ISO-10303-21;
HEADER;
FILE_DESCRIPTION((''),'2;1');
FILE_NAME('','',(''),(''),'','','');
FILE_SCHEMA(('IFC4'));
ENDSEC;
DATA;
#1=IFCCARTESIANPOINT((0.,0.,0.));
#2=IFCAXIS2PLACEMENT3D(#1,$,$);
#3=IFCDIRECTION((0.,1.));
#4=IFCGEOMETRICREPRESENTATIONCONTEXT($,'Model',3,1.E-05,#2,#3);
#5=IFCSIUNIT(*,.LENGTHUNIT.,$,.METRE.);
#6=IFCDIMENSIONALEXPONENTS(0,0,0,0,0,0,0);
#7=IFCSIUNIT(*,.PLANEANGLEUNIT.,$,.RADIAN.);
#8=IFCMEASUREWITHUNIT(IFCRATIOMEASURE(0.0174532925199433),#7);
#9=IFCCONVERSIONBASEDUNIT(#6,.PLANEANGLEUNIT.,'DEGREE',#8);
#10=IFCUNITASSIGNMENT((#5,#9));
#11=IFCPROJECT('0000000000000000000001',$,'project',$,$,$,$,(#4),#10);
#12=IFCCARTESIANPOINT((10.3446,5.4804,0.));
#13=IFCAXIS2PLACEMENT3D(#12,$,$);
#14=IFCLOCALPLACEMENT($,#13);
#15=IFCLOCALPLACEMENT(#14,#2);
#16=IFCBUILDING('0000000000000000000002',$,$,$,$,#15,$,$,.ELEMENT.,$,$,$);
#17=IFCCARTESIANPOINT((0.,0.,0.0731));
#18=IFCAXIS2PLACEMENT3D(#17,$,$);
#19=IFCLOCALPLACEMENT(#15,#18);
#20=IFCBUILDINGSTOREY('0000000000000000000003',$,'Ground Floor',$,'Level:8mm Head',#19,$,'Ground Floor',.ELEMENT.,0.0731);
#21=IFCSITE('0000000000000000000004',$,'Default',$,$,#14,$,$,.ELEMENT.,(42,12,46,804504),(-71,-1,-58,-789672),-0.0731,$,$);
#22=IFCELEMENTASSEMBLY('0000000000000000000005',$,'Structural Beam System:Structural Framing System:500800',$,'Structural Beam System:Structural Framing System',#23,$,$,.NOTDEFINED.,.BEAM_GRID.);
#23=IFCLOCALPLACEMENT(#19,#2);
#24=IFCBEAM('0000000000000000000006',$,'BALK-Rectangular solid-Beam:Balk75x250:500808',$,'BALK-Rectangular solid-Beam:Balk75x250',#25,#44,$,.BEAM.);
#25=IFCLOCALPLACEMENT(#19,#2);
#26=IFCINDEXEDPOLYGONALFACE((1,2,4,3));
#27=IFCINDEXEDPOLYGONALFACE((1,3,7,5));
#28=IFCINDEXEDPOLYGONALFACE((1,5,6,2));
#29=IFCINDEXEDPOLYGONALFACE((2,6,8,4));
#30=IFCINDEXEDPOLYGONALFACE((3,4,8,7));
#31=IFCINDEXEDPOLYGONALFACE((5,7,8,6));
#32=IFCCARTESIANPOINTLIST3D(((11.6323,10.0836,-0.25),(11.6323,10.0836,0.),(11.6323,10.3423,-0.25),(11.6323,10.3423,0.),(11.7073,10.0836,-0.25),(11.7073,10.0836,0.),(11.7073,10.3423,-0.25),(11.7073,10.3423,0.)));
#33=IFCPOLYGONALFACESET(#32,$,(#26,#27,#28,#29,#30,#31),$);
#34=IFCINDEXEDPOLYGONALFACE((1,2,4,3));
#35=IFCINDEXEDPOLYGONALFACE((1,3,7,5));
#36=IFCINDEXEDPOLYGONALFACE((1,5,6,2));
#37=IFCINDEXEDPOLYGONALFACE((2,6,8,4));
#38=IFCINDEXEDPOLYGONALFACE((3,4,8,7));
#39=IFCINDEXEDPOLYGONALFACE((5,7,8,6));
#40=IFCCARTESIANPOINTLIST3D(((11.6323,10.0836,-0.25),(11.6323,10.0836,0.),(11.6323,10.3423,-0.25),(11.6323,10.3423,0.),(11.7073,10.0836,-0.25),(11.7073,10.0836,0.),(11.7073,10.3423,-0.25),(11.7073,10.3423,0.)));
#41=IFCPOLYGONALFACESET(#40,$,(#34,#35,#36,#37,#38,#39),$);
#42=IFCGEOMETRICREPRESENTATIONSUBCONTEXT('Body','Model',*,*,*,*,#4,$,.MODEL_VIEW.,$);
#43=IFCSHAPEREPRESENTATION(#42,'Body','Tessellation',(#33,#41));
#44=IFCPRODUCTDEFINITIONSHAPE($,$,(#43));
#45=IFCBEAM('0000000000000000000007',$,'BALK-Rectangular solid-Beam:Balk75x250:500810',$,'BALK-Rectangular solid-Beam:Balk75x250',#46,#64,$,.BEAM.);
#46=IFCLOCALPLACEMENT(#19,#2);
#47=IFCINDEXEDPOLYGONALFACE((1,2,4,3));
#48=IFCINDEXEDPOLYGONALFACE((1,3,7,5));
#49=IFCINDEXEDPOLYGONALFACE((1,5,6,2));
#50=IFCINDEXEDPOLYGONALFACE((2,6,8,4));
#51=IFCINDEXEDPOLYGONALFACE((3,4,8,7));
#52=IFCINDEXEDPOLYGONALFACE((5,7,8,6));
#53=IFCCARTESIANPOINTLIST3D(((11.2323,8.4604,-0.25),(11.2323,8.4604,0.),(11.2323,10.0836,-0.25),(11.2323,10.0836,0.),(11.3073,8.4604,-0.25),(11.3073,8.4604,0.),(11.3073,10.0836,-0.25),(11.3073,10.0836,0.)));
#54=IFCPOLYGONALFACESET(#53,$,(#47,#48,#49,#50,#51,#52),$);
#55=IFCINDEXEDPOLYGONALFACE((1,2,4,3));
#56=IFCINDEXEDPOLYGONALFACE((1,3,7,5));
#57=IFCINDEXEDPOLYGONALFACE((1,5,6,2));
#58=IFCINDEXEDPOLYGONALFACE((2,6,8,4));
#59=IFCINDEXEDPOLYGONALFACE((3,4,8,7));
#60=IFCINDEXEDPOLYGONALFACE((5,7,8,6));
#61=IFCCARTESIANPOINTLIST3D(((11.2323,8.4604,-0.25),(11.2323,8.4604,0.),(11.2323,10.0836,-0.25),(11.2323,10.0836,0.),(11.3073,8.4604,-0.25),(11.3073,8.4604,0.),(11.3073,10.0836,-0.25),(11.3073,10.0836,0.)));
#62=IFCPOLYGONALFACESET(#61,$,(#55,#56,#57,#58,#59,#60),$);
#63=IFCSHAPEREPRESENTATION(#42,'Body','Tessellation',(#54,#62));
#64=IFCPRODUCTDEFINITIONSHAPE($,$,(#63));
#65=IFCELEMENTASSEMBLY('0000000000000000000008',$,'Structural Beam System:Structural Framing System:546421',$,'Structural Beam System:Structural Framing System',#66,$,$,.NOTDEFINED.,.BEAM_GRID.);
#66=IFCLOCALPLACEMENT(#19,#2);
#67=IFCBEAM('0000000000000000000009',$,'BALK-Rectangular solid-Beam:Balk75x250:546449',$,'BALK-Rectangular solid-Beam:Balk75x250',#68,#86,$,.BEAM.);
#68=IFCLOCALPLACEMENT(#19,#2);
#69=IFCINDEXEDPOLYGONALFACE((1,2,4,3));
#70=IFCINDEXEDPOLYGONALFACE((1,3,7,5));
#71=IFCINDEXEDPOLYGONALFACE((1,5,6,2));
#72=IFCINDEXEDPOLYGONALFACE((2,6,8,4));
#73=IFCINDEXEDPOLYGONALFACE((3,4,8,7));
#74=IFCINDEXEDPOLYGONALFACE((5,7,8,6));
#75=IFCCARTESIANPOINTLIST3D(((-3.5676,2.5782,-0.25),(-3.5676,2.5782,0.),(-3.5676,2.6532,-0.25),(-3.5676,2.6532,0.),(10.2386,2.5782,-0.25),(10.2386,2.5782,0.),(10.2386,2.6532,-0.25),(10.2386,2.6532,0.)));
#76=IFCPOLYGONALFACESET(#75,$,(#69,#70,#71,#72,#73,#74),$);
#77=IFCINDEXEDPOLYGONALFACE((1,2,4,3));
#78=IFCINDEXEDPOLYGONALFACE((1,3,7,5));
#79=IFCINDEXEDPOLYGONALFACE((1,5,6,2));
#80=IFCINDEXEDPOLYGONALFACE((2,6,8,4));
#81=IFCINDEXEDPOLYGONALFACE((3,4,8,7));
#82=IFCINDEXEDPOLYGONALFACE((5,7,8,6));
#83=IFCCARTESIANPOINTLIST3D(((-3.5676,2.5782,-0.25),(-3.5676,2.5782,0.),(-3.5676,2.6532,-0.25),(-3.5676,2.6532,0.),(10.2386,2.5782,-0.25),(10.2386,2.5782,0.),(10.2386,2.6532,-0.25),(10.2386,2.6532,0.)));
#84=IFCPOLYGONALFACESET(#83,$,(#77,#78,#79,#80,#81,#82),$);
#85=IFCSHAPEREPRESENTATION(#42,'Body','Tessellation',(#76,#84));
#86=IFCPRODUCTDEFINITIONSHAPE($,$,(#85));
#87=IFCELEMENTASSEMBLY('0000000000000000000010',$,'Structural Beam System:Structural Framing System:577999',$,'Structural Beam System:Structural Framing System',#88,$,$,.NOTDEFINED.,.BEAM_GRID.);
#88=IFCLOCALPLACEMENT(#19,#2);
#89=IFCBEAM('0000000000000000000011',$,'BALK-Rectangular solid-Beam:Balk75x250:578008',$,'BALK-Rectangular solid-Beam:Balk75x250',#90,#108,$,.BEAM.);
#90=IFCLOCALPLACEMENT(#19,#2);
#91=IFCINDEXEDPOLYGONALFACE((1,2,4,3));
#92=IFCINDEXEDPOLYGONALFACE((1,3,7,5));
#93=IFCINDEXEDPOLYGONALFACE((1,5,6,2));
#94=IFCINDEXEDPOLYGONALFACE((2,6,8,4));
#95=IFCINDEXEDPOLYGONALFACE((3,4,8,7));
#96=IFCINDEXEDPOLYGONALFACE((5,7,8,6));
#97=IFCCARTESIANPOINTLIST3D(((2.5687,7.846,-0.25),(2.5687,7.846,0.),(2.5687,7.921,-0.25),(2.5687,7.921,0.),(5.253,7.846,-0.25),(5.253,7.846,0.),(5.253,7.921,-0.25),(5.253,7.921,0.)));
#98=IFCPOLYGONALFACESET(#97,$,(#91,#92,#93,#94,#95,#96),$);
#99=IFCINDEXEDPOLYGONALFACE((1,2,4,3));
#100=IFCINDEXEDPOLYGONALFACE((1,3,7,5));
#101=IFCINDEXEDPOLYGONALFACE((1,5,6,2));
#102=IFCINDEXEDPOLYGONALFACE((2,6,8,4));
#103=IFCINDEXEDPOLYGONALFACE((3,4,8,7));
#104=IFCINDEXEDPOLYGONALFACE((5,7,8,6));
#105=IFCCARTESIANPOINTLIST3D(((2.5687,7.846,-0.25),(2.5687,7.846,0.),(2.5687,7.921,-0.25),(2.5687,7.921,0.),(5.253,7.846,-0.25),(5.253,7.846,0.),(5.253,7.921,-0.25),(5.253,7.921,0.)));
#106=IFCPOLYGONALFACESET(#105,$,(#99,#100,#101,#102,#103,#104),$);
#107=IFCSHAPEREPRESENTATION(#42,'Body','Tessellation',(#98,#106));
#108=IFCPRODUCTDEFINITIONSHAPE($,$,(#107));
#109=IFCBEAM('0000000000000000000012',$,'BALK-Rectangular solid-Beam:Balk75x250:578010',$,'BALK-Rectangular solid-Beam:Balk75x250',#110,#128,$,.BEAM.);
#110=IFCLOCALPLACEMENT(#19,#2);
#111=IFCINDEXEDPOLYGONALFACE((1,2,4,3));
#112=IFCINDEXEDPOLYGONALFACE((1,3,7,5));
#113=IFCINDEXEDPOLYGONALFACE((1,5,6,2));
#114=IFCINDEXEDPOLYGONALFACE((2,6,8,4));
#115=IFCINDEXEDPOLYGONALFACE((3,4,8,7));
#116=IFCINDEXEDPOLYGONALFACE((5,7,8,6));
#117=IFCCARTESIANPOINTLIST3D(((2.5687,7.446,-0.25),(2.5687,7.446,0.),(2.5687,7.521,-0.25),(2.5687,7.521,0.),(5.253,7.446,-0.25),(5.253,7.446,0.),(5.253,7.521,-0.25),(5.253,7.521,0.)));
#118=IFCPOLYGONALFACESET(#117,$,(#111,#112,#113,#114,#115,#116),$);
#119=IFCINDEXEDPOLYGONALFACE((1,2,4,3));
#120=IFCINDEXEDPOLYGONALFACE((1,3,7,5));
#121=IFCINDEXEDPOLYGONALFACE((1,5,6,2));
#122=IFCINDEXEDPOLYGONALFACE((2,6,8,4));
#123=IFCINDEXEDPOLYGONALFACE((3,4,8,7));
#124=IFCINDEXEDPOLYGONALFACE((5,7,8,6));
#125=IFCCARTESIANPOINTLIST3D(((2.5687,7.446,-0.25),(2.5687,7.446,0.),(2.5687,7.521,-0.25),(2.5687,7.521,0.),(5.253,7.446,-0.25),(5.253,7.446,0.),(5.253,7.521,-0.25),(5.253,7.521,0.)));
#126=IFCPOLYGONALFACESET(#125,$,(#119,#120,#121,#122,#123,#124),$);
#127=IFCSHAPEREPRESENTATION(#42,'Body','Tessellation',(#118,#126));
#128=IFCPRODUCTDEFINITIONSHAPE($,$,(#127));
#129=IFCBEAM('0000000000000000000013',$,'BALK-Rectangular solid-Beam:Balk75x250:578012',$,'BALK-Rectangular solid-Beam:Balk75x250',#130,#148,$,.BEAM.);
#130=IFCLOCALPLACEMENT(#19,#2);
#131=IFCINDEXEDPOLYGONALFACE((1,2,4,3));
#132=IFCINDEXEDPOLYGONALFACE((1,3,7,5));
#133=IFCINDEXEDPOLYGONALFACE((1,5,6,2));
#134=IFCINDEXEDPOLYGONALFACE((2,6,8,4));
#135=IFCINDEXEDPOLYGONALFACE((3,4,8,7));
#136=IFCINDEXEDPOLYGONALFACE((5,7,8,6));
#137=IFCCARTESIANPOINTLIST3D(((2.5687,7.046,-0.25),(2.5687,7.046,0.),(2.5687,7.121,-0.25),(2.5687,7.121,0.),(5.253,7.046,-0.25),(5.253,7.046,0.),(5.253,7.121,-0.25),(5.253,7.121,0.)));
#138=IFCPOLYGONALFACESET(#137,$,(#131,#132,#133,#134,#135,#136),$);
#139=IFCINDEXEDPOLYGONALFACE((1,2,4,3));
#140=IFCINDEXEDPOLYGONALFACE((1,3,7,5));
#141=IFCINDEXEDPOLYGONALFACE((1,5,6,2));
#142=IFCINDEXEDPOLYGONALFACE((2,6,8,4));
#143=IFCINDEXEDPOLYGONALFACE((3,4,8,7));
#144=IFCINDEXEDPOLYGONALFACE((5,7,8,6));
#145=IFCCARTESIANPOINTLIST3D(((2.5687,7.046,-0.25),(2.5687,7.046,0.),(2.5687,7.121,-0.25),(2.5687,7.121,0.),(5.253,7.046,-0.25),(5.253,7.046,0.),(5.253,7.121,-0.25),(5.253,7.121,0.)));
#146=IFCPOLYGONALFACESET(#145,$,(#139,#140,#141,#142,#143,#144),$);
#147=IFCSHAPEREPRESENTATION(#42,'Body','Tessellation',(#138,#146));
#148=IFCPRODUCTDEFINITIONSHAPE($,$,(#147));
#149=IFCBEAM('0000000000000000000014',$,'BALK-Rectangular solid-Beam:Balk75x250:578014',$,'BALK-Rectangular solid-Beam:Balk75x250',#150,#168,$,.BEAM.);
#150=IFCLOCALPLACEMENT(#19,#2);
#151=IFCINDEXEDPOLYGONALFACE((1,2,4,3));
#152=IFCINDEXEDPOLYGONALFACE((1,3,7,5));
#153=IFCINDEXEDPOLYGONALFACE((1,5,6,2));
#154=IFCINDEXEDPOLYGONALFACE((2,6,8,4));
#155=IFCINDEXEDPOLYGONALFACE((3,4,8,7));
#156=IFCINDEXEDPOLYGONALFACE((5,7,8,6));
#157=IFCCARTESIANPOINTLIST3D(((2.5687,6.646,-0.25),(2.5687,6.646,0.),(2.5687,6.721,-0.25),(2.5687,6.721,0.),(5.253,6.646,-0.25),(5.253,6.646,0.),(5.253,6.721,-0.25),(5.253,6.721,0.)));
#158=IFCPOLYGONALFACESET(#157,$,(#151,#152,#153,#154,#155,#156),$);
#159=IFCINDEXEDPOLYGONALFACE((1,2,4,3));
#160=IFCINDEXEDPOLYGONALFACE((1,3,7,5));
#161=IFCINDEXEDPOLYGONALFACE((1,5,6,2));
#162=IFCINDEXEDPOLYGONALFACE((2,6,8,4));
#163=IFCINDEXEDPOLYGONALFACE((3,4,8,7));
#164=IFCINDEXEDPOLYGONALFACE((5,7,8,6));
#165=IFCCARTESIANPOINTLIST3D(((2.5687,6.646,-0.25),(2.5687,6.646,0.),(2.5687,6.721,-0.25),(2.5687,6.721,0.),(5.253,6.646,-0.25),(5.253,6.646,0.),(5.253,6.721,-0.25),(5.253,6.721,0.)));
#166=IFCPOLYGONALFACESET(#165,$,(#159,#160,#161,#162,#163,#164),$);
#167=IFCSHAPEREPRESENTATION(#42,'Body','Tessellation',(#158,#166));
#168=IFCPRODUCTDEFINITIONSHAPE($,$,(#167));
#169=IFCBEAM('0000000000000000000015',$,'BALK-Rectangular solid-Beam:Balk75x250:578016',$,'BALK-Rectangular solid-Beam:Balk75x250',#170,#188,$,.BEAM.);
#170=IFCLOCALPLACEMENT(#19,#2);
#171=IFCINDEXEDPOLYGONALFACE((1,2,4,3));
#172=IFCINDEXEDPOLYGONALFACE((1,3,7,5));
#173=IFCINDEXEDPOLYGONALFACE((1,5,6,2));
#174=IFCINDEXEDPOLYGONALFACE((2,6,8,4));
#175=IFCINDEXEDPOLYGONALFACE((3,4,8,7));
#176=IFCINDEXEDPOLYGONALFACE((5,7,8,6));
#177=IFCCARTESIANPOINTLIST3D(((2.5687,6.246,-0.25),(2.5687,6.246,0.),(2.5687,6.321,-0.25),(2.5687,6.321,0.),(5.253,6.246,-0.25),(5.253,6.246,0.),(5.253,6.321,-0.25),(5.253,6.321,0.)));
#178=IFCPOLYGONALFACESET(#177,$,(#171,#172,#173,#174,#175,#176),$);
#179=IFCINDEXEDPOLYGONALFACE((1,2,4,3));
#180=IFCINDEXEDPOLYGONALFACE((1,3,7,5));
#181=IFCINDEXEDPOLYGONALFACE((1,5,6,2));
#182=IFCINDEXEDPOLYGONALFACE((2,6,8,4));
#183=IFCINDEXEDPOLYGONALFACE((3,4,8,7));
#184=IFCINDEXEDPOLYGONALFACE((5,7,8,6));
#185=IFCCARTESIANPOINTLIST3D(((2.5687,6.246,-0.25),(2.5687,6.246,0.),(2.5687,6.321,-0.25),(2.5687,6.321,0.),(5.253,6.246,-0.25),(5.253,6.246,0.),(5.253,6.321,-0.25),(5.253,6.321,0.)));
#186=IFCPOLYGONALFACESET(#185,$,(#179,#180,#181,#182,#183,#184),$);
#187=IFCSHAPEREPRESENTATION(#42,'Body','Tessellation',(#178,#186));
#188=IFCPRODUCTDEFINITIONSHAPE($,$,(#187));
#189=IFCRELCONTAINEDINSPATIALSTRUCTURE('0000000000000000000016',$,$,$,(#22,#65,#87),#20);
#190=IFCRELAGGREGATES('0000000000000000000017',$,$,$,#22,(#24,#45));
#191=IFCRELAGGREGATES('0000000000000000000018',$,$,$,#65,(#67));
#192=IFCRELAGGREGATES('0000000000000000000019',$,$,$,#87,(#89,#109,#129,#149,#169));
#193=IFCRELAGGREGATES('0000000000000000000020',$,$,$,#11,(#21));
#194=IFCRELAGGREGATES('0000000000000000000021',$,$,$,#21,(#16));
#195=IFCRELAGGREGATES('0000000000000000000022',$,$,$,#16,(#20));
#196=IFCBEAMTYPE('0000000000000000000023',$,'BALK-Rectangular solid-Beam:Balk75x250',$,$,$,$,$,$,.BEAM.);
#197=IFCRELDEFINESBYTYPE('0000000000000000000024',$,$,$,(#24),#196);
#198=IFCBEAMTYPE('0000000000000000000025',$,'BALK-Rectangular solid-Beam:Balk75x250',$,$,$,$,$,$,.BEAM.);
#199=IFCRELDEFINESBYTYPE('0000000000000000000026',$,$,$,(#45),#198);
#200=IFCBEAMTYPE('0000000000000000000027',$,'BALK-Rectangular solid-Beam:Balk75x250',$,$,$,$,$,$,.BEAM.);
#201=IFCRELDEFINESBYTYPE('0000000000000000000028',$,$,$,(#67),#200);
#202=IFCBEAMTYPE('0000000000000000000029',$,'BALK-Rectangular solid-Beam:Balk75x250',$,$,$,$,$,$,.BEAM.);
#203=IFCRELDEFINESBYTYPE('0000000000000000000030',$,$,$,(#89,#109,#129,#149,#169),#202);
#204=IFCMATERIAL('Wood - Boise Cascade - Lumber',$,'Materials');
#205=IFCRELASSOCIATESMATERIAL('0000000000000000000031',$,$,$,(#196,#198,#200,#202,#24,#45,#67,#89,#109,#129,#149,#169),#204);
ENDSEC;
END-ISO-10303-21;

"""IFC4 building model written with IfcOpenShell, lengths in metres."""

from ifc_helpers import new_model, entity, si_unit, converted_unit, direction, frame, frame_2d, origin, origin_2d_with_axis, place, context, subcontext, project, spatial, rectangle, extrude, source, transform, mapped, material, material_profile, profile_set, profile_usage, type_object, type_shapes, element, aggregate, save


model = new_model("IFC4")

# Units and contexts
model_context = context("Model", 3, precision=1e-05, world=origin(), true_north=direction((0.0, 1.0)))
body_context = subcontext(model_context, "Body", "Model", "MODEL_VIEW")
ifc_project = project(units=[si_unit("LENGTHUNIT", "METRE"), converted_unit("PLANEANGLEUNIT", "DEGREE", entity("IfcRatioMeasure", 0.0174532925199433), si_unit("PLANEANGLEUNIT", "RADIAN"), dimensions=[0, 0, 0, 0, 0, 0, 0])], contexts=[model_context])

# Site, building, storey
site_placement = place(None, frame((10.3446, 5.4804, 0.0)))
site = spatial("IfcSite", under=ifc_project, at=site_placement, Name="Default", CompositionType="ELEMENT", RefLatitude=(42, 12, 46, 804504), RefLongitude=(-71, -1, -58, -789672), RefElevation=-0.0731)
building_placement = place(site_placement, origin())
building = spatial("IfcBuilding", under=site, at=building_placement, CompositionType="ELEMENT")
storey_placement = place(building_placement, frame((0.0, 0.0, 0.0731)))
storey = spatial("IfcBuildingStorey", under=building, at=storey_placement, Name="Ground Floor", ObjectType="Level:8mm Head", LongName="Ground Floor", CompositionType="ELEMENT", Elevation=0.0731)

# Element assembly, beams
assembly_1_placement = place(storey_placement, origin())
assembly_1 = element("IfcElementAssembly", 1, at=assembly_1_placement, inside=storey, Name="Structural Beam System:Structural Framing System:500800", ObjectType="Structural Beam System:Structural Framing System", AssemblyPlace="NOTDEFINED", PredefinedType="BEAM_GRID")
ifc_material_1 = material(Name="Wood - Boise Cascade - Lumber", Category="Materials")
ifc_material_profile = material_profile(ifc_material_1, rectangle(XDim=0.25, YDim=0.075, at=frame_2d((0.0, 0.0), x_axis=(1.0, 0.0))), Name="Balk75x250")
ifc_profile_set = profile_set([ifc_material_profile], Name="Balk75x250")
ifc_profile_usage_1 = profile_usage(ifc_profile_set, cardinal=8)
beam_type_1 = type_object("IfcBeamType", Name="BALK-Rectangular solid-Beam:Balk75x250", PredefinedType="BEAM", material=ifc_profile_set)
shared_shape_1 = source(origin(), body_context, "Body", "SweptSolid", [
    extrude(rectangle(XDim=0.25, YDim=0.075, at=frame_2d((0.0, 0.0), x_axis=(0.0, 1.0))), frame((11.6698, 10.3423, -0.0519), z_axis=(0.0, -1.0, 0.0), x_axis=(-1.0, 0.0, 0.0)), (0.0, 0.0, 1.0), 0.2587),
    extrude(rectangle(XDim=0.25, YDim=0.075, at=frame_2d((0.0, 0.0), x_axis=(0.0, 1.0))), frame((11.6698, 10.3423, -0.0519), z_axis=(0.0, -1.0, 0.0), x_axis=(-1.0, 0.0, 0.0)), (0.0, 0.0, 1.0), 0.2587),
])
type_shapes(beam_type_1, [shared_shape_1])
beam_1_placement = place(assembly_1_placement, frame((0.0, 0.0, -0.0731)))
beam_1 = element("IfcBeam", 2, at=beam_1_placement, type_object=beam_type_1, material=ifc_profile_usage_1, Name="BALK-Rectangular solid-Beam:Balk75x250:500808", ObjectType="BALK-Rectangular solid-Beam:Balk75x250", PredefinedType="BEAM", context=body_context, shape_type="MappedRepresentation", body=[
    mapped(shared_shape_1, transform((0.0, 0.0, 0.0), scale=1.0)),
])
ifc_profile_usage_2 = profile_usage(ifc_profile_set, cardinal=8)
beam_type_2 = type_object("IfcBeamType", Name="BALK-Rectangular solid-Beam:Balk75x250", PredefinedType="BEAM", material=ifc_profile_set)
shared_shape_2 = source(origin(), body_context, "Body", "SweptSolid", [
    extrude(rectangle(XDim=0.25, YDim=0.075, at=frame_2d((0.0, 0.0), x_axis=(0.0, 1.0))), frame((11.2698, 10.0836, -0.0519), z_axis=(0.0, -1.0, 0.0), x_axis=(-1.0, 0.0, 0.0)), (0.0, 0.0, 1.0), 1.6232),
    extrude(rectangle(XDim=0.25, YDim=0.075, at=frame_2d((0.0, 0.0), x_axis=(0.0, 1.0))), frame((11.2698, 10.0836, -0.0519), z_axis=(0.0, -1.0, 0.0), x_axis=(-1.0, 0.0, 0.0)), (0.0, 0.0, 1.0), 1.6232),
])
type_shapes(beam_type_2, [shared_shape_2])
beam_2_placement = place(assembly_1_placement, frame((0.0, 0.0, -0.0731)))
beam_2 = element("IfcBeam", 3, at=beam_2_placement, type_object=beam_type_2, material=ifc_profile_usage_2, Name="BALK-Rectangular solid-Beam:Balk75x250:500810", ObjectType="BALK-Rectangular solid-Beam:Balk75x250", PredefinedType="BEAM", context=body_context, shape_type="MappedRepresentation", body=[
    mapped(shared_shape_2, transform((0.0, 0.0, 0.0), scale=1.0)),
])
aggregate(assembly_1, [beam_1, beam_2])

# Element assembly, beam
assembly_2_placement = place(storey_placement, origin())
assembly_2 = element("IfcElementAssembly", 4, at=assembly_2_placement, inside=storey, Name="Structural Beam System:Structural Framing System:546421", ObjectType="Structural Beam System:Structural Framing System", AssemblyPlace="NOTDEFINED", PredefinedType="BEAM_GRID")
ifc_profile_usage_3 = profile_usage(ifc_profile_set, cardinal=8)
beam_type_3 = type_object("IfcBeamType", Name="BALK-Rectangular solid-Beam:Balk75x250", PredefinedType="BEAM", material=ifc_profile_set)
shared_shape_3 = source(origin(), body_context, "Body", "SweptSolid", [
    extrude(rectangle(XDim=0.25, YDim=0.075, at=origin_2d_with_axis()), frame((-6.9023, 0.0, 0.0), z_axis=(1.0, 0.0, 0.0), x_axis=(0.0, 0.0, -1.0)), (0.0, 0.0, 1.0), 13.8062),
    extrude(rectangle(XDim=0.25, YDim=0.075, at=origin_2d_with_axis()), frame((-6.9023, 0.0, 0.0), z_axis=(1.0, 0.0, 0.0), x_axis=(0.0, 0.0, -1.0)), (0.0, 0.0, 1.0), 13.8062),
])
type_shapes(beam_type_3, [shared_shape_3])
beam_3_placement = place(assembly_2_placement, frame((3.3363, 2.6157, -0.125), z_axis=(0.0, 0.0, 1.0), x_axis=(-1.0, 0.0, 0.0)))
beam_3 = element("IfcBeam", 5, at=beam_3_placement, type_object=beam_type_3, material=ifc_profile_usage_3, Name="BALK-Rectangular solid-Beam:Balk75x250:546449", ObjectType="BALK-Rectangular solid-Beam:Balk75x250", PredefinedType="BEAM", context=body_context, shape_type="MappedRepresentation", body=[
    mapped(shared_shape_3, transform((0.0, 0.0, 0.0), scale=1.0)),
])
aggregate(assembly_2, [beam_3])

# Element assembly, beams
assembly_3_placement = place(storey_placement, origin())
assembly_3 = element("IfcElementAssembly", 6, at=assembly_3_placement, inside=storey, Name="Structural Beam System:Structural Framing System:577999", ObjectType="Structural Beam System:Structural Framing System", AssemblyPlace="NOTDEFINED", PredefinedType="BEAM_GRID")
ifc_profile_usage_4 = profile_usage(ifc_profile_set, cardinal=8)
beam_type_4 = type_object("IfcBeamType", Name="BALK-Rectangular solid-Beam:Balk75x250", PredefinedType="BEAM", material=ifc_profile_set)
shared_shape_4 = source(origin(), body_context, "Body", "SweptSolid", [
    extrude(rectangle(XDim=0.25, YDim=0.075, at=origin_2d_with_axis()), frame((-1.3484, 0.0, 0.0), z_axis=(1.0, 0.0, 0.0), x_axis=(0.0, 0.0, -1.0)), (0.0, 0.0, 1.0), 2.6844),
    extrude(rectangle(XDim=0.25, YDim=0.075, at=origin_2d_with_axis()), frame((-1.3484, 0.0, 0.0), z_axis=(1.0, 0.0, 0.0), x_axis=(0.0, 0.0, -1.0)), (0.0, 0.0, 1.0), 2.6844),
])
type_shapes(beam_type_4, [shared_shape_4])
beam_4_placement = place(assembly_3_placement, frame((3.9171, 7.8835, -0.125)))
beam_4 = element("IfcBeam", 7, at=beam_4_placement, type_object=beam_type_4, material=ifc_profile_usage_4, Name="BALK-Rectangular solid-Beam:Balk75x250:578008", ObjectType="BALK-Rectangular solid-Beam:Balk75x250", PredefinedType="BEAM", context=body_context, shape_type="MappedRepresentation", body=[
    mapped(shared_shape_4, transform((0.0, 0.0, 0.0), scale=1.0)),
])
ifc_profile_usage_5 = profile_usage(ifc_profile_set, cardinal=8)
beam_5_placement = place(assembly_3_placement, frame((3.9171, 7.4835, -0.125)))
beam_5 = element("IfcBeam", 8, at=beam_5_placement, type_object=beam_type_4, material=ifc_profile_usage_5, Name="BALK-Rectangular solid-Beam:Balk75x250:578010", ObjectType="BALK-Rectangular solid-Beam:Balk75x250", PredefinedType="BEAM", context=body_context, shape_type="MappedRepresentation", body=[
    mapped(shared_shape_4, transform((0.0, 0.0, 0.0), scale=1.0)),
])
ifc_profile_usage_6 = profile_usage(ifc_profile_set, cardinal=8)
beam_6_placement = place(assembly_3_placement, frame((3.9171, 7.0835, -0.125)))
beam_6 = element("IfcBeam", 9, at=beam_6_placement, type_object=beam_type_4, material=ifc_profile_usage_6, Name="BALK-Rectangular solid-Beam:Balk75x250:578012", ObjectType="BALK-Rectangular solid-Beam:Balk75x250", PredefinedType="BEAM", context=body_context, shape_type="MappedRepresentation", body=[
    mapped(shared_shape_4, transform((0.0, 0.0, 0.0), scale=1.0)),
])
ifc_profile_usage_7 = profile_usage(ifc_profile_set, cardinal=8)
beam_7_placement = place(assembly_3_placement, frame((3.9171, 6.6835, -0.125)))
beam_7 = element("IfcBeam", 10, at=beam_7_placement, type_object=beam_type_4, material=ifc_profile_usage_7, Name="BALK-Rectangular solid-Beam:Balk75x250:578014", ObjectType="BALK-Rectangular solid-Beam:Balk75x250", PredefinedType="BEAM", context=body_context, shape_type="MappedRepresentation", body=[
    mapped(shared_shape_4, transform((0.0, 0.0, 0.0), scale=1.0)),
])
ifc_profile_usage_8 = profile_usage(ifc_profile_set, cardinal=8)
beam_8_placement = place(assembly_3_placement, frame((3.9171, 6.2835, -0.125)))
beam_8 = element("IfcBeam", 11, at=beam_8_placement, type_object=beam_type_4, material=ifc_profile_usage_8, Name="BALK-Rectangular solid-Beam:Balk75x250:578016", ObjectType="BALK-Rectangular solid-Beam:Balk75x250", PredefinedType="BEAM", context=body_context, shape_type="MappedRepresentation", body=[
    mapped(shared_shape_4, transform((0.0, 0.0, 0.0), scale=1.0)),
])
aggregate(assembly_3, [beam_4, beam_5, beam_6, beam_7, beam_8])

save(model, "model.ifc")
